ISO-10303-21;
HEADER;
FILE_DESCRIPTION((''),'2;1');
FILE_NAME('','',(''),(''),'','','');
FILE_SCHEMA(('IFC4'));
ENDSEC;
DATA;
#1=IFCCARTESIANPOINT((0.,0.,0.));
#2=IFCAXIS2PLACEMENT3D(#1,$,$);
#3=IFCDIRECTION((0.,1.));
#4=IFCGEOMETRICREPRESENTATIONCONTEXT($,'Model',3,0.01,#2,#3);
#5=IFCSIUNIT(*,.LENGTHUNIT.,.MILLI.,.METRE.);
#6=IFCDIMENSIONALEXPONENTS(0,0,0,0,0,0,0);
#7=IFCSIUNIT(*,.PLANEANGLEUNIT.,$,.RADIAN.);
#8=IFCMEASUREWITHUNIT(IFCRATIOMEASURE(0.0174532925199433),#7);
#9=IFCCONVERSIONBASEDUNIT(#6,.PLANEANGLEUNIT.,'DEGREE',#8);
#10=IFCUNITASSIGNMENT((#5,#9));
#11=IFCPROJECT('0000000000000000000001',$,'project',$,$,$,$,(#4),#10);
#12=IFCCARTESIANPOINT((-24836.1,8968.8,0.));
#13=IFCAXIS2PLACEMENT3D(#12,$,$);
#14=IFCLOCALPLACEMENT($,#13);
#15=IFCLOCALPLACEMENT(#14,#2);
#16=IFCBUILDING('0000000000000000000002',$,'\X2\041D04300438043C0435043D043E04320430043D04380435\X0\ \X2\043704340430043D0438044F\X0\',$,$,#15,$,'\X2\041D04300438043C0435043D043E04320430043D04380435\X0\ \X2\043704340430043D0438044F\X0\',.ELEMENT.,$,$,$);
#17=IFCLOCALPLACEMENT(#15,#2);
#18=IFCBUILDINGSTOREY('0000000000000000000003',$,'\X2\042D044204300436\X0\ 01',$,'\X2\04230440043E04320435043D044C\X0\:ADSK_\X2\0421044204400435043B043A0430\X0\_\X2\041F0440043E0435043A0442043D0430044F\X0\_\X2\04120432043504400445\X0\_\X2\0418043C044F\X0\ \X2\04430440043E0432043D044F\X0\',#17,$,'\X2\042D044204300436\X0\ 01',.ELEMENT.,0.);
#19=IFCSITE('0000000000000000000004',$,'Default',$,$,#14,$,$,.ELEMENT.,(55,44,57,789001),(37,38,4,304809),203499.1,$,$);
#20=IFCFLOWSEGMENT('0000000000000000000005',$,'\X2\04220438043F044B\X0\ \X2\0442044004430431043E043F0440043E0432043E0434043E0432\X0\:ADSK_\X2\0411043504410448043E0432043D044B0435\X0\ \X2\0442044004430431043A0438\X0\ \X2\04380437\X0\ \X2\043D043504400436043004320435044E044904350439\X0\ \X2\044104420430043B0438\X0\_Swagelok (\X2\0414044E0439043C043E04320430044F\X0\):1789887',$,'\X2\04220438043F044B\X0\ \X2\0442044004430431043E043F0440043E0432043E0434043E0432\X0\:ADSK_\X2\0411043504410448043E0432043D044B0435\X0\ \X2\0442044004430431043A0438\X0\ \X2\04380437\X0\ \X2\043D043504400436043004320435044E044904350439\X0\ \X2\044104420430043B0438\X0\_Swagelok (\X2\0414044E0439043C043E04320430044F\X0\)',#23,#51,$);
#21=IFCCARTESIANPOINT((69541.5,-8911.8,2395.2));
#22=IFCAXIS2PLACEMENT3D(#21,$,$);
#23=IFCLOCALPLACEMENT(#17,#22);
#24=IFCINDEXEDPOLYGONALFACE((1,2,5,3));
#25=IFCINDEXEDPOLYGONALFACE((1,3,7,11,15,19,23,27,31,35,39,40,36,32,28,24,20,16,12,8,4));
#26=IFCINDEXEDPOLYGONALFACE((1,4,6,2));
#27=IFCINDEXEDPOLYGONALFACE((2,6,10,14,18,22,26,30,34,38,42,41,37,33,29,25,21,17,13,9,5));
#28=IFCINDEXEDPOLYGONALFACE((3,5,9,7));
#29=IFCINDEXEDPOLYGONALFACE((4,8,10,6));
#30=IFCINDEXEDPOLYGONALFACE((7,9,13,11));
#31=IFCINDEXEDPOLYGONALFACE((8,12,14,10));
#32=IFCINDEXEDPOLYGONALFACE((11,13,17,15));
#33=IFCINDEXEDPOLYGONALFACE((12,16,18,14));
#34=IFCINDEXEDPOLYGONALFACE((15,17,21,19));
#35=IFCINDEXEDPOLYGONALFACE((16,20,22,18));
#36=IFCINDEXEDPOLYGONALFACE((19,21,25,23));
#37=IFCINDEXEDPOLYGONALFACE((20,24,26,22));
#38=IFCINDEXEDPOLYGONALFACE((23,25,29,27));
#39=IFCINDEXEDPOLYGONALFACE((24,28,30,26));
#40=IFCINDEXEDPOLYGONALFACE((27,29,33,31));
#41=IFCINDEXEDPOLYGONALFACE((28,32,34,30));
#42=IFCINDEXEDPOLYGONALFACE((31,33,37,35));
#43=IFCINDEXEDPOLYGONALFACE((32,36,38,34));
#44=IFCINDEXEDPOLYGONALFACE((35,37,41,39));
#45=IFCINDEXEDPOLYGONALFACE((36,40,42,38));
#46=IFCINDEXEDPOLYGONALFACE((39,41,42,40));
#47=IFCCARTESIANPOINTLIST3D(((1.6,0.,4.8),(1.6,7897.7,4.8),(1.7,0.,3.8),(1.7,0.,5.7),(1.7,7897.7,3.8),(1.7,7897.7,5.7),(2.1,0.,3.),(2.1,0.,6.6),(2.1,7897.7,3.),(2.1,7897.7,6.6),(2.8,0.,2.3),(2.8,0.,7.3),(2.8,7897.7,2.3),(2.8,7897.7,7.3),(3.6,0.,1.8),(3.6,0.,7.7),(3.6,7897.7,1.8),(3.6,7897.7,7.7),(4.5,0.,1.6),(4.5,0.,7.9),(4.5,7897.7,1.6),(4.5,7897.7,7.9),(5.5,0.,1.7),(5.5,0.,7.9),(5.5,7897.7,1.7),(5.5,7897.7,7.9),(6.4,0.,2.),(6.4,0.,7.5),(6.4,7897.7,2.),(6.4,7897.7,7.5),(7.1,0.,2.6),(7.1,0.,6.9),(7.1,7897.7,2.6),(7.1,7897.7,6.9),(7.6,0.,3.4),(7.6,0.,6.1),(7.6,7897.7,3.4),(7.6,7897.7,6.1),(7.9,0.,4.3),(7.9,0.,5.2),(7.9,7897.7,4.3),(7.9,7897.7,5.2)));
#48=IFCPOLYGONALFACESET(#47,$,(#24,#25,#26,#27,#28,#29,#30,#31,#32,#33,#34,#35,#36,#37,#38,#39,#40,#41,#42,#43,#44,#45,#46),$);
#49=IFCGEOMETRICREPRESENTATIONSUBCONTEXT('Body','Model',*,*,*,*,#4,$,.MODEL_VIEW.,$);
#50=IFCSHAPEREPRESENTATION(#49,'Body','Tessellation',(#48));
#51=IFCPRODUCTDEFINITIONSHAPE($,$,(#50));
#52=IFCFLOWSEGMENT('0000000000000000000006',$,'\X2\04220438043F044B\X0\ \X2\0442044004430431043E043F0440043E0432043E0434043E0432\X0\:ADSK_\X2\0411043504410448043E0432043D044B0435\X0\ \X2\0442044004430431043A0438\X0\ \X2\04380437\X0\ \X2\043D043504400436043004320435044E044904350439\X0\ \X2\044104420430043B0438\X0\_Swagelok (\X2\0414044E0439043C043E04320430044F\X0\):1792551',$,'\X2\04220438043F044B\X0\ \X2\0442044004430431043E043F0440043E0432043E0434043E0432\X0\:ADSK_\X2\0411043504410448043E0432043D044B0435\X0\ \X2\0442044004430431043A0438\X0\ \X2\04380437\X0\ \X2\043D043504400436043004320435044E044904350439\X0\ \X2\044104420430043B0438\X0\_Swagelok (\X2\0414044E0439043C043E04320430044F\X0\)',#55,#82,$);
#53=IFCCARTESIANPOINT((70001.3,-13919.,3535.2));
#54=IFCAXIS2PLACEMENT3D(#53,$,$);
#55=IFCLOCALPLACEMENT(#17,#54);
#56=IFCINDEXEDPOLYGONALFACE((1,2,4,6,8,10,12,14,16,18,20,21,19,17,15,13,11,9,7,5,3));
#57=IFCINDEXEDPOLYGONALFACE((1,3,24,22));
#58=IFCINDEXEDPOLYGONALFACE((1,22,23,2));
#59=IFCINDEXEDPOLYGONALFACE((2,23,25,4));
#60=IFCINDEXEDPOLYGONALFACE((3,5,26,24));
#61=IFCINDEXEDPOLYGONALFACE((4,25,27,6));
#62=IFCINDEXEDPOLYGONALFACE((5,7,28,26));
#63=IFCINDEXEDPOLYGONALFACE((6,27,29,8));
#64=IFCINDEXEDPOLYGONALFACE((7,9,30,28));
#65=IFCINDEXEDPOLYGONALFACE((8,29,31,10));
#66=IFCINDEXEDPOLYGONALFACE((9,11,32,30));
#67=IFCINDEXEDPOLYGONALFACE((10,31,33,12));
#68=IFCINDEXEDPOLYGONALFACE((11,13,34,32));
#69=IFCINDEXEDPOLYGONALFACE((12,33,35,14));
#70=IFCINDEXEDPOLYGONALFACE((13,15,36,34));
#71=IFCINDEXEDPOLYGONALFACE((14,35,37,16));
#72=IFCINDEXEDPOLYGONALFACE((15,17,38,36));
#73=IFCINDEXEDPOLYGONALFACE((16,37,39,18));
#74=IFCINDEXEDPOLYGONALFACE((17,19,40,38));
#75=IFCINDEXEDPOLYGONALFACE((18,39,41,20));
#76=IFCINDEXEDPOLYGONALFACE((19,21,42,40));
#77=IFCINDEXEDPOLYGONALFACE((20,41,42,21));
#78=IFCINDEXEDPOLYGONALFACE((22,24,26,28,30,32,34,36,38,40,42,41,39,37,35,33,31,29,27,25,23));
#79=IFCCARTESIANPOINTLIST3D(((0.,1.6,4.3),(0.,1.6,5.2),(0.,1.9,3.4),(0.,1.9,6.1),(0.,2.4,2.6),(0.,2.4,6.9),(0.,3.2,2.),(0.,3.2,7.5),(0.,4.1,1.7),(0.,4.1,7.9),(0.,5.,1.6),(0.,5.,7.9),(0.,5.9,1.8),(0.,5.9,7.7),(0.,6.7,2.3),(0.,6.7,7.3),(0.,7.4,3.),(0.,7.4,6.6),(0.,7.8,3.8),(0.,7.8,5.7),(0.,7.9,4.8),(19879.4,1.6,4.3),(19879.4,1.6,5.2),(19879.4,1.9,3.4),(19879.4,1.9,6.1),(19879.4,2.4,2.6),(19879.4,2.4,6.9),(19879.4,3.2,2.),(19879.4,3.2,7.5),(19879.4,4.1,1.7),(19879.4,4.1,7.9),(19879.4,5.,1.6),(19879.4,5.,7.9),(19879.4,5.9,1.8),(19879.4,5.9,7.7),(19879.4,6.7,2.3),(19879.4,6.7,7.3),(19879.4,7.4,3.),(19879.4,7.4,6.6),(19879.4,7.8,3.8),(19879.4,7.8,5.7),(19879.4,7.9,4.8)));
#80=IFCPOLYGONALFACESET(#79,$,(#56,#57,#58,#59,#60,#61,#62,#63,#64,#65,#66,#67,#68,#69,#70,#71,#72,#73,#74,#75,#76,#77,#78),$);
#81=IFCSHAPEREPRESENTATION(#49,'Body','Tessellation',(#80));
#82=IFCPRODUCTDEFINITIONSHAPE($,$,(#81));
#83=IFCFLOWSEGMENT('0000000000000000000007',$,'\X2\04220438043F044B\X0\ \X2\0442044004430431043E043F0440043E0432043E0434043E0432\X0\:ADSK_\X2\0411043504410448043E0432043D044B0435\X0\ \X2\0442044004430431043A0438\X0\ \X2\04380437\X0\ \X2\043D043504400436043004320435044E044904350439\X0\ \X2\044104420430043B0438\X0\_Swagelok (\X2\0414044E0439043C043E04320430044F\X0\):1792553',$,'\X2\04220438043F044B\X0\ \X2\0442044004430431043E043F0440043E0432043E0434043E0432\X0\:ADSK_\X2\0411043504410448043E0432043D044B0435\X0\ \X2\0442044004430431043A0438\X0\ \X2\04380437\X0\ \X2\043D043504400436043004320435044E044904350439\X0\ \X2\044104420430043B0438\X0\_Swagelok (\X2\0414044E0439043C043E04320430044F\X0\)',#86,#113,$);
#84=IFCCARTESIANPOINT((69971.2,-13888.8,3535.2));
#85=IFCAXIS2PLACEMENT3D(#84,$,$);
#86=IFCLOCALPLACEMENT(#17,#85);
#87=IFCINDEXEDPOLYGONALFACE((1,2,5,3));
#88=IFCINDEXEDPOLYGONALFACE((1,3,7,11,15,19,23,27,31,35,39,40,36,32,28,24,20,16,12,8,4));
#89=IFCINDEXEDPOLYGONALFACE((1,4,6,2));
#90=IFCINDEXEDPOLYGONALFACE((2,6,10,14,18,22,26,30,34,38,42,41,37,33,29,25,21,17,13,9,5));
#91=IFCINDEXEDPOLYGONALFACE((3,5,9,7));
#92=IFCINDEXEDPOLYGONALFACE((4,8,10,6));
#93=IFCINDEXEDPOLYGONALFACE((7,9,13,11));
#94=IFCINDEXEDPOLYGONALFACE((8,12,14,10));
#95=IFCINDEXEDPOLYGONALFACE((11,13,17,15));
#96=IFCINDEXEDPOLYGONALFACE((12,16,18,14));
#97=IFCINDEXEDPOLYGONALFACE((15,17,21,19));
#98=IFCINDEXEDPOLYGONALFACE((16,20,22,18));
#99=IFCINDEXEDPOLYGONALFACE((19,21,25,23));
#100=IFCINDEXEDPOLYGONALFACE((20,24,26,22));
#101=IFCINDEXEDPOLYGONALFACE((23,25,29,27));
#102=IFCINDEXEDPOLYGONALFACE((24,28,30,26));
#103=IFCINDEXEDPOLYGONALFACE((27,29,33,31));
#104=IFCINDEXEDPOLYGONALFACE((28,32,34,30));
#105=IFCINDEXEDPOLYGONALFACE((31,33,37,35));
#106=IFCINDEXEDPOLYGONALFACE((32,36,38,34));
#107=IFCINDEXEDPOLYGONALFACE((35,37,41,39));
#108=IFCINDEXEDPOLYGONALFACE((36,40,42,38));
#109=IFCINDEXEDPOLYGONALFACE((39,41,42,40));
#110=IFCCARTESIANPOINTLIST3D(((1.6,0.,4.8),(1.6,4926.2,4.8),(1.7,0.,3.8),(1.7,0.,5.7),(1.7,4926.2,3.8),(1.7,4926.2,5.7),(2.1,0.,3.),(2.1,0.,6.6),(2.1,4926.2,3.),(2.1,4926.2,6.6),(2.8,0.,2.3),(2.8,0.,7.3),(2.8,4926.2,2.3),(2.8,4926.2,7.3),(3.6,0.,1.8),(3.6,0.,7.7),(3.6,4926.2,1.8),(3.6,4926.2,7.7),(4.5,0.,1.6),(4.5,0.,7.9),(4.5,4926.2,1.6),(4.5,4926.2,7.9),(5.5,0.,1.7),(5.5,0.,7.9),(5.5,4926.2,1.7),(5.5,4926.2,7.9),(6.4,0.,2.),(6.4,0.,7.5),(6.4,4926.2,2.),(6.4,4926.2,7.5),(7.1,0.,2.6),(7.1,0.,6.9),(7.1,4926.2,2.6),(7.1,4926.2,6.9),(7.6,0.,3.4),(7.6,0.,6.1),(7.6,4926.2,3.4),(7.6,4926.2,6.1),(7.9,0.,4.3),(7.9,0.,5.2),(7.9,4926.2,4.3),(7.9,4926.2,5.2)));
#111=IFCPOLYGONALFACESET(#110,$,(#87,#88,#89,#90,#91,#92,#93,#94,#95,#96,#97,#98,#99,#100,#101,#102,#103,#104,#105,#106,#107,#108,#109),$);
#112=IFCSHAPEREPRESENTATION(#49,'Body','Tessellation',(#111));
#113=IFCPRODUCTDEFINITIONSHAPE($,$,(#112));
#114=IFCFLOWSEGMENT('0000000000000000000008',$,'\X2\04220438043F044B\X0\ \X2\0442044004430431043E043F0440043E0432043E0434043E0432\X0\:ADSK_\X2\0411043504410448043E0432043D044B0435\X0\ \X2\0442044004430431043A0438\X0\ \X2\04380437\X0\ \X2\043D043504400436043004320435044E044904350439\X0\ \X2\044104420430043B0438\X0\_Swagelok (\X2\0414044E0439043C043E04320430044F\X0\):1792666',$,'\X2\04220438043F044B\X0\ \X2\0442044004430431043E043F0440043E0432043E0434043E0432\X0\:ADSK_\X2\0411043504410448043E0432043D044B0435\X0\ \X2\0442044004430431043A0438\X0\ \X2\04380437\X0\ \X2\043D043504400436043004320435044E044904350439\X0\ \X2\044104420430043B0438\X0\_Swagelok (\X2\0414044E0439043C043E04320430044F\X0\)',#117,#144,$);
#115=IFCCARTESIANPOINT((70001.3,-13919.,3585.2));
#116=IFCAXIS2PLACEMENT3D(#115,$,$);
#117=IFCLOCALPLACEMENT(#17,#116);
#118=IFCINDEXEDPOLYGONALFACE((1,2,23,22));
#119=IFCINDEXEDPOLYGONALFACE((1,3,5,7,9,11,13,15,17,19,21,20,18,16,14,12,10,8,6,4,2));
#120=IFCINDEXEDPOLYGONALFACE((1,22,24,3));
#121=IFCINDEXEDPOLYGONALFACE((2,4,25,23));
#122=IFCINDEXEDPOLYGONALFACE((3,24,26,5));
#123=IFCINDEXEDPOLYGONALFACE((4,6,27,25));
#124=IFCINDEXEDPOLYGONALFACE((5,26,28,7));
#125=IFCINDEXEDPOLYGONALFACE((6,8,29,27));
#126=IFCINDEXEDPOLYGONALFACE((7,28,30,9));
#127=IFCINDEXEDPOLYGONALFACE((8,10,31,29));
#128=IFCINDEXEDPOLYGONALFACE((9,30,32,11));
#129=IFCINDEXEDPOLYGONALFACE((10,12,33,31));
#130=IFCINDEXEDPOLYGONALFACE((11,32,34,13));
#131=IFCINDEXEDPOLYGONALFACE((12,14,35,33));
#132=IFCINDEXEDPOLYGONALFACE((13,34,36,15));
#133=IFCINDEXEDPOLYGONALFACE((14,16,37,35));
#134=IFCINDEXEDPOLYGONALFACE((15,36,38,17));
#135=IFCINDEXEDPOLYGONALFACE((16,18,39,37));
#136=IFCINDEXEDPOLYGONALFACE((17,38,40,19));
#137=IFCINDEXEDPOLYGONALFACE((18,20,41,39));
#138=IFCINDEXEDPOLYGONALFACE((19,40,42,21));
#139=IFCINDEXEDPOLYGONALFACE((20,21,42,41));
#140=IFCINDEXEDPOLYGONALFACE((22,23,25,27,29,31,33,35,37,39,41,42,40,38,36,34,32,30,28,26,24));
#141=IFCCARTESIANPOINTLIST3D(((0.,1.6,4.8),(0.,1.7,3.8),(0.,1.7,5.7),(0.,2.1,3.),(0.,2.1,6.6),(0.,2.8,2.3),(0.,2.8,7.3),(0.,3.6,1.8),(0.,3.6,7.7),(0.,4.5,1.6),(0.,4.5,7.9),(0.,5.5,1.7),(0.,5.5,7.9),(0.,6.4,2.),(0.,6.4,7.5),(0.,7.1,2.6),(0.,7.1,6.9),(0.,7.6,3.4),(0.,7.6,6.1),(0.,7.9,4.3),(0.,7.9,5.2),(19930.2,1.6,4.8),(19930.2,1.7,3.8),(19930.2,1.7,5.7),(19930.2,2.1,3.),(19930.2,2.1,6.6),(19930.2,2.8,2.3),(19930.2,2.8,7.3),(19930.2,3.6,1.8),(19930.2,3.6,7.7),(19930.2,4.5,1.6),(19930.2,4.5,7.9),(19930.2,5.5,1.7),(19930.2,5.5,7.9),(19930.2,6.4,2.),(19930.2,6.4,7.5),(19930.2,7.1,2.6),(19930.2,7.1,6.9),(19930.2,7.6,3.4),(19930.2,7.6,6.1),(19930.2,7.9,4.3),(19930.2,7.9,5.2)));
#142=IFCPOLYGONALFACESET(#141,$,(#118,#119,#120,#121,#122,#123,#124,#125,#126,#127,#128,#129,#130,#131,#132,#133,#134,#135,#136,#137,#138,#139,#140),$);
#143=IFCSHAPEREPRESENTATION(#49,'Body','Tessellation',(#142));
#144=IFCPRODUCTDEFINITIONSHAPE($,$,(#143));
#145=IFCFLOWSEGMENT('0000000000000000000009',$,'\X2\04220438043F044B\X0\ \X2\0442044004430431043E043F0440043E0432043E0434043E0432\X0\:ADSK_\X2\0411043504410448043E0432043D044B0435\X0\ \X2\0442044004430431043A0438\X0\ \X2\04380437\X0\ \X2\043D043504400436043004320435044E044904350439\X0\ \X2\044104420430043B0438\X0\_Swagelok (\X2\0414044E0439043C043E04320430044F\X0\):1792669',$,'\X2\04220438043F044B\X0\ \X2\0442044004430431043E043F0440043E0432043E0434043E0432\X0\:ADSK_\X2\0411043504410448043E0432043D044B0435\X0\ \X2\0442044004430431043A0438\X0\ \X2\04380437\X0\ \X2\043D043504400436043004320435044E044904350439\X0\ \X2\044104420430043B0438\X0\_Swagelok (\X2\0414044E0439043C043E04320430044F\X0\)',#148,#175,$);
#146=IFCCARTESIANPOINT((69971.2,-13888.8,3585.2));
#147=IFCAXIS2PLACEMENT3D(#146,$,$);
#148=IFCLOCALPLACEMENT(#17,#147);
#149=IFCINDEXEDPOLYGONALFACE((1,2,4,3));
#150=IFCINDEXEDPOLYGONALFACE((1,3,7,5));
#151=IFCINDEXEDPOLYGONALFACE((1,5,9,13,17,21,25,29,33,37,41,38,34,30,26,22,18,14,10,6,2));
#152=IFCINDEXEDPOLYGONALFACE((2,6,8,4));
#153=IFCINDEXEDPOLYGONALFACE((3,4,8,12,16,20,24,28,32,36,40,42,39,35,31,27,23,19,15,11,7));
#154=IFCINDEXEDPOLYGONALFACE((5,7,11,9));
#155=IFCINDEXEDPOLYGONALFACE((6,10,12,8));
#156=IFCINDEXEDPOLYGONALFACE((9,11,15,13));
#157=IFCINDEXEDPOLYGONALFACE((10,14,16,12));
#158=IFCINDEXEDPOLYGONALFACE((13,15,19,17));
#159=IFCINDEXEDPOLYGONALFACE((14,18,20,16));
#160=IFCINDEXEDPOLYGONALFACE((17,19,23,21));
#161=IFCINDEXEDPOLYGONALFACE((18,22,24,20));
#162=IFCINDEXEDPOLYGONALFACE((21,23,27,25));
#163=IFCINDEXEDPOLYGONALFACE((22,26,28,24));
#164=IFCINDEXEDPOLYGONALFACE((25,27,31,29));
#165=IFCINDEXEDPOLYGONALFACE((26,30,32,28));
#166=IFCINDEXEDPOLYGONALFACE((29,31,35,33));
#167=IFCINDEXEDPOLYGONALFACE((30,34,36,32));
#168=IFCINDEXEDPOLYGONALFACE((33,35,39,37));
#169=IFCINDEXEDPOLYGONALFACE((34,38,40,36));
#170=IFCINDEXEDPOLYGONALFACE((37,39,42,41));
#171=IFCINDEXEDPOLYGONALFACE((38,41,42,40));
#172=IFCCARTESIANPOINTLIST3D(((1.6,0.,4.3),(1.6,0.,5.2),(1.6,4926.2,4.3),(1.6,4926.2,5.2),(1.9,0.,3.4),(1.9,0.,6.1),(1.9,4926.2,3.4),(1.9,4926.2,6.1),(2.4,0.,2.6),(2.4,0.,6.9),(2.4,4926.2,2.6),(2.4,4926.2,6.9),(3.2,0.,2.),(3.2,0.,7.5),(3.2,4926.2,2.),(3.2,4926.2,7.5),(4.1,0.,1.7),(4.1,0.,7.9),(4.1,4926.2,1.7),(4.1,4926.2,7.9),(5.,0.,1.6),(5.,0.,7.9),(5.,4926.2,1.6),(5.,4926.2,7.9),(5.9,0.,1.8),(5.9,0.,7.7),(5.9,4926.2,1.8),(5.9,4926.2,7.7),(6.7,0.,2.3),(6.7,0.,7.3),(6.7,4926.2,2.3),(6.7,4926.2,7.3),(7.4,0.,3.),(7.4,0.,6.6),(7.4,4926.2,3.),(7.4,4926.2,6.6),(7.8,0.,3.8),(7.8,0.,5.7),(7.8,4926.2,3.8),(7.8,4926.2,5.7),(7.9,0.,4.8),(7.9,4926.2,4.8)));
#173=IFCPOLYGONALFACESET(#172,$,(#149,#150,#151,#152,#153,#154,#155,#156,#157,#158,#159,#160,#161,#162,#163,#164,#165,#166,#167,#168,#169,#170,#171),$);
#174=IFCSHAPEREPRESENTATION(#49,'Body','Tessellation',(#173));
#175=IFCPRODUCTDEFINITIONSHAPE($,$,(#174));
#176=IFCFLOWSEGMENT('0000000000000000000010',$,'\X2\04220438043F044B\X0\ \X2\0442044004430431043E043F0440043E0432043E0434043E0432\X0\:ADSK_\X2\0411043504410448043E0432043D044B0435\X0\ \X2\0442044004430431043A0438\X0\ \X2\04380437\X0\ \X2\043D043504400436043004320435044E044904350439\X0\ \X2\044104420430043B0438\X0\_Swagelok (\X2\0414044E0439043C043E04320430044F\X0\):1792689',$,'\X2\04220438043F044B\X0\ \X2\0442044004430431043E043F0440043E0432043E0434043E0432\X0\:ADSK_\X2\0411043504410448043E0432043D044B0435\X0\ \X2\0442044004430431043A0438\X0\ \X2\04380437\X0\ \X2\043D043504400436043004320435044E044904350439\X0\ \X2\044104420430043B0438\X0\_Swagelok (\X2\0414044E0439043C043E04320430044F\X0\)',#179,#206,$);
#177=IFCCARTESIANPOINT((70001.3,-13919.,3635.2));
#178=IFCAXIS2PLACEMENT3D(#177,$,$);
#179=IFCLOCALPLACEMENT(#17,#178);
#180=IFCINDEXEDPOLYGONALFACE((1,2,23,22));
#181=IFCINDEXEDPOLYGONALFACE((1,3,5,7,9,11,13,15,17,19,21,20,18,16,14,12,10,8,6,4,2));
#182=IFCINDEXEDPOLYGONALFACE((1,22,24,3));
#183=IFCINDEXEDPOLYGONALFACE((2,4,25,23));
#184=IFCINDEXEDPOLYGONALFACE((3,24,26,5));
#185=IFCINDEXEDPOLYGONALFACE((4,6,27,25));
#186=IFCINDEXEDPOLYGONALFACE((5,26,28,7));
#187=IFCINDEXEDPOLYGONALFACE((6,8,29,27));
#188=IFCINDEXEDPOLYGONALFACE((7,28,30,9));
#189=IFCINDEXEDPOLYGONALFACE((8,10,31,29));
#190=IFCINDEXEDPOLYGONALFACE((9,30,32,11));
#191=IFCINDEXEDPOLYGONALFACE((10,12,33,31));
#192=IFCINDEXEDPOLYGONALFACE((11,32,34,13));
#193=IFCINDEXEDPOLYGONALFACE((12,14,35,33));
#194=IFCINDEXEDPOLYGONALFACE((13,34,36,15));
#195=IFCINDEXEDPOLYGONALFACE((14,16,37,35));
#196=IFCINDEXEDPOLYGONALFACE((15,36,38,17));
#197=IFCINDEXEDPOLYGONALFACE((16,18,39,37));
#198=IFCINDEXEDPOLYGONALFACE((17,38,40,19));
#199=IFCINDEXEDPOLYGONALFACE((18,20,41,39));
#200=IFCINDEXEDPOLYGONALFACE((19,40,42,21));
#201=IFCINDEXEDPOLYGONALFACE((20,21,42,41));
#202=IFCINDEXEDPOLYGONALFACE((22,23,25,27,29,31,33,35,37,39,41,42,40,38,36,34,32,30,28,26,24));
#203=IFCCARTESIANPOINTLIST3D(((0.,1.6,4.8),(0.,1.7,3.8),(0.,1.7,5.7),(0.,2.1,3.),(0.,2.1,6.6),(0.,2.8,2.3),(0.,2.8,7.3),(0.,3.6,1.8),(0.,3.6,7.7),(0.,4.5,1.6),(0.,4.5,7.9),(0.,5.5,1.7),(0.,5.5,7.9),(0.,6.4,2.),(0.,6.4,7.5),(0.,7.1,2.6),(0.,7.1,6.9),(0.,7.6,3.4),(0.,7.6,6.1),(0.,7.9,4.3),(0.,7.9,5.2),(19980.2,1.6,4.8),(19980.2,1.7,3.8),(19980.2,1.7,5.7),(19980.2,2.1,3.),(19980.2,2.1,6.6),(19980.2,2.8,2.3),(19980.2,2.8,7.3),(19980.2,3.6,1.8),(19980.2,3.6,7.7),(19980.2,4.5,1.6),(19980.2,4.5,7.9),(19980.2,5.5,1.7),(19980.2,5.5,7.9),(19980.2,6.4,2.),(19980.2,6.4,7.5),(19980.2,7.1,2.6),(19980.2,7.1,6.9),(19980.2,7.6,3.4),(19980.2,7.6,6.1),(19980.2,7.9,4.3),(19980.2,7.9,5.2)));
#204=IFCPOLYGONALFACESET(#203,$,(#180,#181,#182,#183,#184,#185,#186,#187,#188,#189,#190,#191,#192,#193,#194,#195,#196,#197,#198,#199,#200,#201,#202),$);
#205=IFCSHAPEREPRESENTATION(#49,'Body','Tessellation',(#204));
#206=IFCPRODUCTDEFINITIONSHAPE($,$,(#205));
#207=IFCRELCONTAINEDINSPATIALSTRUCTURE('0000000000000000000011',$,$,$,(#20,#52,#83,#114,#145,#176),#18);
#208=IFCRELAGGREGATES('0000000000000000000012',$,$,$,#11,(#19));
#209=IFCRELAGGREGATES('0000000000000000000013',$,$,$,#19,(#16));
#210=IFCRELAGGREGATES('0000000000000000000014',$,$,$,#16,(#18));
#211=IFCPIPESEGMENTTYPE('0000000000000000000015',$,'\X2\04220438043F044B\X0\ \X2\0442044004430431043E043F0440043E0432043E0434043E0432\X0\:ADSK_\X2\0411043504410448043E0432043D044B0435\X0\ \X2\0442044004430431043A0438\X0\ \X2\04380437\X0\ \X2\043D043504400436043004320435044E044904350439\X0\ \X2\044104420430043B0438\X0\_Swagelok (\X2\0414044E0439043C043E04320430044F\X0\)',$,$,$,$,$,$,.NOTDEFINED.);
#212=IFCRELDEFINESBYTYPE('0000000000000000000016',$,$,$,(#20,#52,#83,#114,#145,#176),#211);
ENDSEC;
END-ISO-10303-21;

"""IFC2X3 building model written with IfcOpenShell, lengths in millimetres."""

from ifc_helpers import new_model, entity, si_unit, converted_unit, direction, frame, origin, origin_2d_with_axis, place, context, subcontext, project, spatial, circle, extrude, type_object, element, save


model = new_model("IFC2X3")

# Units and contexts
model_context = context("Model", 3, precision=0.01, world=origin(), true_north=direction((0.0, 1.0)))
body_context = subcontext(model_context, "Body", "Model", "MODEL_VIEW")
ifc_project = project(units=[si_unit("LENGTHUNIT", "METRE", prefix="MILLI"), converted_unit("PLANEANGLEUNIT", "DEGREE", entity("IfcRatioMeasure", 0.0174532925199433), si_unit("PLANEANGLEUNIT", "RADIAN"), dimensions=[0, 0, 0, 0, 0, 0, 0])], contexts=[model_context])

# Site, building, storey
site_placement = place(None, frame((-24836.1, 8968.8, 0.0)))
site = spatial("IfcSite", under=ifc_project, at=site_placement, Name="Default", CompositionType="ELEMENT", RefLatitude=(55, 44, 57, 789001), RefLongitude=(37, 38, 4, 304809), RefElevation=203499.1)
building_placement = place(site_placement, origin())
building = spatial("IfcBuilding", under=site, at=building_placement, Name="Наименование здания", LongName="Наименование здания", CompositionType="ELEMENT")
storey_placement = place(building_placement, origin())
storey = spatial("IfcBuildingStorey", under=building, at=storey_placement, Name="Этаж 01", ObjectType="Уровень:ADSK_Стрелка_Проектная_Вверх_Имя уровня", LongName="Этаж 01", CompositionType="ELEMENT", Elevation=0.0)

# Flow segments
pipe_segment_type_1 = type_object("IfcPipeSegmentType", Name="Типы трубопроводов:ADSK_Бесшовные трубки из нержавеющей стали_Swagelok (Дюймовая)", PredefinedType="NOTDEFINED")
flow_segment_1_placement = place(storey_placement, frame((69541.5, -8911.8, 2395.2)))
element("IfcFlowSegment", 1, at=flow_segment_1_placement, inside=storey, type_object=pipe_segment_type_1, Name="Типы трубопроводов:ADSK_Бесшовные трубки из нержавеющей стали_Swagelok (Дюймовая):1789887", ObjectType="Типы трубопроводов:ADSK_Бесшовные трубки из нержавеющей стали_Swagelok (Дюймовая)", context=body_context, shape_type="SweptSolid", body=[
    extrude(circle(Radius=3.2, at=origin_2d_with_axis()), frame((4.8, 0.0, 4.8), z_axis=(0.0, 1.0, 0.0), x_axis=(-1.0, 0.0, 0.0)), (0.0, 0.0, 1.0), 7897.7),
])
flow_segment_2_placement = place(storey_placement, frame((70001.3, -13919.0, 3535.2)))
element("IfcFlowSegment", 2, at=flow_segment_2_placement, inside=storey, type_object=pipe_segment_type_1, Name="Типы трубопроводов:ADSK_Бесшовные трубки из нержавеющей стали_Swagelok (Дюймовая):1792551", ObjectType="Типы трубопроводов:ADSK_Бесшовные трубки из нержавеющей стали_Swagelok (Дюймовая)", context=body_context, shape_type="SweptSolid", body=[
    extrude(circle(Radius=3.2, at=origin_2d_with_axis()), frame((0.0, 4.8, 4.8), z_axis=(1.0, 0.0, 0.0), x_axis=(0.0, 1.0, 0.0)), (0.0, 0.0, 1.0), 19879.4),
])
flow_segment_3_placement = place(storey_placement, frame((69971.2, -13888.8, 3535.2)))
element("IfcFlowSegment", 3, at=flow_segment_3_placement, inside=storey, type_object=pipe_segment_type_1, Name="Типы трубопроводов:ADSK_Бесшовные трубки из нержавеющей стали_Swagelok (Дюймовая):1792553", ObjectType="Типы трубопроводов:ADSK_Бесшовные трубки из нержавеющей стали_Swagelok (Дюймовая)", context=body_context, shape_type="SweptSolid", body=[
    extrude(circle(Radius=3.2, at=origin_2d_with_axis()), frame((4.8, 0.0, 4.8), z_axis=(0.0, 1.0, 0.0), x_axis=(-1.0, 0.0, 0.0)), (0.0, 0.0, 1.0), 4926.2),
])
flow_segment_4_placement = place(storey_placement, frame((70001.3, -13919.0, 3585.2)))
element("IfcFlowSegment", 4, at=flow_segment_4_placement, inside=storey, type_object=pipe_segment_type_1, Name="Типы трубопроводов:ADSK_Бесшовные трубки из нержавеющей стали_Swagelok (Дюймовая):1792666", ObjectType="Типы трубопроводов:ADSK_Бесшовные трубки из нержавеющей стали_Swagelok (Дюймовая)", context=body_context, shape_type="SweptSolid", body=[
    extrude(circle(Radius=3.2, at=origin_2d_with_axis()), frame((0.0, 4.8, 4.8), z_axis=(1.0, 0.0, 0.0), x_axis=(0.0, -1.0, 0.0)), (0.0, 0.0, 1.0), 19930.2),
])
flow_segment_5_placement = place(storey_placement, frame((69971.2, -13888.8, 3585.2)))
element("IfcFlowSegment", 5, at=flow_segment_5_placement, inside=storey, type_object=pipe_segment_type_1, Name="Типы трубопроводов:ADSK_Бесшовные трубки из нержавеющей стали_Swagelok (Дюймовая):1792669", ObjectType="Типы трубопроводов:ADSK_Бесшовные трубки из нержавеющей стали_Swagelok (Дюймовая)", context=body_context, shape_type="SweptSolid", body=[
    extrude(circle(Radius=3.2, at=origin_2d_with_axis()), frame((4.8, 0.0, 4.8), z_axis=(0.0, 1.0, 0.0), x_axis=(1.0, 0.0, 0.0)), (0.0, 0.0, 1.0), 4926.2),
])
flow_segment_6_placement = place(storey_placement, frame((70001.3, -13919.0, 3635.2)))
element("IfcFlowSegment", 6, at=flow_segment_6_placement, inside=storey, type_object=pipe_segment_type_1, Name="Типы трубопроводов:ADSK_Бесшовные трубки из нержавеющей стали_Swagelok (Дюймовая):1792689", ObjectType="Типы трубопроводов:ADSK_Бесшовные трубки из нержавеющей стали_Swagelok (Дюймовая)", context=body_context, shape_type="SweptSolid", body=[
    extrude(circle(Radius=3.2, at=origin_2d_with_axis()), frame((0.0, 4.8, 4.8), z_axis=(1.0, 0.0, 0.0), x_axis=(0.0, -1.0, 0.0)), (0.0, 0.0, 1.0), 19980.2),
])

save(model, "model.ifc")
